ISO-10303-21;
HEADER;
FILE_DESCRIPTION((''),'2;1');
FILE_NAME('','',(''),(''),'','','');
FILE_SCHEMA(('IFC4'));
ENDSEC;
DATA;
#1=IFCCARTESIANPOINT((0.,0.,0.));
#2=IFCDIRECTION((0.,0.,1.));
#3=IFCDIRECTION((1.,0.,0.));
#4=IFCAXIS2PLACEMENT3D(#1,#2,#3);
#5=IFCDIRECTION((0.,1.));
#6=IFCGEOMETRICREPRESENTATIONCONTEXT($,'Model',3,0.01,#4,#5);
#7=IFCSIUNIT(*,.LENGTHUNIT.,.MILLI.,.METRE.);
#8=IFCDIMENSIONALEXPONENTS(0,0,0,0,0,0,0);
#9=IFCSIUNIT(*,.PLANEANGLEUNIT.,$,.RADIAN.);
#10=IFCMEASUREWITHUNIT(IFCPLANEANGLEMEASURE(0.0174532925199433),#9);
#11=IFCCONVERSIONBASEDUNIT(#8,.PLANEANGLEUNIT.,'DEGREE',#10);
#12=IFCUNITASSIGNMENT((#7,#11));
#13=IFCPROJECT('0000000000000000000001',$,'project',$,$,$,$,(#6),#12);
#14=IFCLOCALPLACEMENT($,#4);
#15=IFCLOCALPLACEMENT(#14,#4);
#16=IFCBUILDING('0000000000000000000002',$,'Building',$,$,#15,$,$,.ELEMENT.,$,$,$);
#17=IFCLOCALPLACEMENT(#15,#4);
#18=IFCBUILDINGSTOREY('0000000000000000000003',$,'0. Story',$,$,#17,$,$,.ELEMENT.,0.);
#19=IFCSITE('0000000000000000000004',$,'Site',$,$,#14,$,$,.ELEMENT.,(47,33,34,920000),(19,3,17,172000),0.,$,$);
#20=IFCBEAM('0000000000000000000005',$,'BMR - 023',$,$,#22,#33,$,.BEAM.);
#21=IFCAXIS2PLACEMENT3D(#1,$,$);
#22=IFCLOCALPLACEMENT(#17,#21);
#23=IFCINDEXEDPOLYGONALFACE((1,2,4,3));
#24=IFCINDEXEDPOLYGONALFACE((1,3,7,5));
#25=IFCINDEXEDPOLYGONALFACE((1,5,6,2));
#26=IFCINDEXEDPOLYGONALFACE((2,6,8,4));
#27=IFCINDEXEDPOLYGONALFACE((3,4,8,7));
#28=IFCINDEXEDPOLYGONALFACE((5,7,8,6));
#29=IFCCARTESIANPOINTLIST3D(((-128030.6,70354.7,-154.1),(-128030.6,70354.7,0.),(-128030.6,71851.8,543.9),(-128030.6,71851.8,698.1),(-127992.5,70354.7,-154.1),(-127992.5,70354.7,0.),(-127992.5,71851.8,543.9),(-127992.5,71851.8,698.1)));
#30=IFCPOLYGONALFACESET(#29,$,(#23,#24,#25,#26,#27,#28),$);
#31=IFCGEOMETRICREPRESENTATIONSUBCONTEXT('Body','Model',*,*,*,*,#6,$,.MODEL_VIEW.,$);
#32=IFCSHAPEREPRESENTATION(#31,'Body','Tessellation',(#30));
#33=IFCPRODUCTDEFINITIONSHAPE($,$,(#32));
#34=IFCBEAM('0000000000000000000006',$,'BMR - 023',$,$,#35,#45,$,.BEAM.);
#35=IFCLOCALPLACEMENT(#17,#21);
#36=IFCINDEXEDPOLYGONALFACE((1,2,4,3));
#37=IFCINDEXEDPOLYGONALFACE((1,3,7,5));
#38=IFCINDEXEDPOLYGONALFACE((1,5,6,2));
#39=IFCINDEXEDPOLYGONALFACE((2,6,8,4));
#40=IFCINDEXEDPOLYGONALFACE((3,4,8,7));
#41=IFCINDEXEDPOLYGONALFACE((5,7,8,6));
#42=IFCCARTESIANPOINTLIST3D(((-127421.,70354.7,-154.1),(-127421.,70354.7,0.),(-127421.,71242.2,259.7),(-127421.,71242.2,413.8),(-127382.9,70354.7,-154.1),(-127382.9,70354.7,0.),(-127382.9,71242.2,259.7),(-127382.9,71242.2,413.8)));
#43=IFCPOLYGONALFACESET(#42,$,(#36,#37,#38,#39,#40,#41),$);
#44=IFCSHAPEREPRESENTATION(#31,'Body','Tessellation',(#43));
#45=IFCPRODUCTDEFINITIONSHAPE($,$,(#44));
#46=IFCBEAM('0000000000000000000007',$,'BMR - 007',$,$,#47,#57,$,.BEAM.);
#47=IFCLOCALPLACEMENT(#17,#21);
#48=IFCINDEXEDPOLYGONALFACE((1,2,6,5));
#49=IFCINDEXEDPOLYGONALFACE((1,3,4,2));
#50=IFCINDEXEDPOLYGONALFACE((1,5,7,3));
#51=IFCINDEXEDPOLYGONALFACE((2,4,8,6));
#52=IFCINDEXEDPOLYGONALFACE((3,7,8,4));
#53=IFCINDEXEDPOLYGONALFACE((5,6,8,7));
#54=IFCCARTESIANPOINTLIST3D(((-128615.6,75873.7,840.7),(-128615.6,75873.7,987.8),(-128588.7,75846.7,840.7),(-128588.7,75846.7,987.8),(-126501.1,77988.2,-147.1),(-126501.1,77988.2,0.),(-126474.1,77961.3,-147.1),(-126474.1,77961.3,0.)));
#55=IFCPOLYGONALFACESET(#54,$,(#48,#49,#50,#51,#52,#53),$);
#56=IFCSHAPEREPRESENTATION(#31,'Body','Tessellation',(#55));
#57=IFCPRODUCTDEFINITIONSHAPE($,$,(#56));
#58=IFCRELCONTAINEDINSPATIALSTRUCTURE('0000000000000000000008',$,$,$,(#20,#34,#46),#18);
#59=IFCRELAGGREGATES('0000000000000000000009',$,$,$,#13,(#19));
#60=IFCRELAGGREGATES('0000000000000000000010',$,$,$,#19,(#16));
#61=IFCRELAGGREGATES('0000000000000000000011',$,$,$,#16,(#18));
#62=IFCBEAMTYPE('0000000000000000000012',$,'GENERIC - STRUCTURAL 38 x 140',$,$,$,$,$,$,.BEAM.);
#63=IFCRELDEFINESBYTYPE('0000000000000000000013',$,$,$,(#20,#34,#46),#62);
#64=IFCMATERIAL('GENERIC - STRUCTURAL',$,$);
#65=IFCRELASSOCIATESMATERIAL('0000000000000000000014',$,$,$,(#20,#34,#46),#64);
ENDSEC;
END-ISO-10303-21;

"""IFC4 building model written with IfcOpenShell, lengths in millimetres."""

from ifc_helpers import new_model, entity, si_unit, converted_unit, direction, frame, frame_2d, origin_with_axes, place, context, subcontext, project, spatial, rectangle, extrude, clip, halfspace, material, type_object, element, save


model = new_model("IFC4")

# Units and contexts
model_context = context("Model", 3, precision=0.01, world=origin_with_axes(), true_north=direction((0.0, 1.0)))
body_context = subcontext(model_context, "Body", "Model", "MODEL_VIEW")
ifc_project = project(units=[si_unit("LENGTHUNIT", "METRE", prefix="MILLI"), converted_unit("PLANEANGLEUNIT", "DEGREE", entity("IfcPlaneAngleMeasure", 0.0174532925199433), si_unit("PLANEANGLEUNIT", "RADIAN"), dimensions=[0, 0, 0, 0, 0, 0, 0])], contexts=[model_context])

# Site, building, storey
site_placement = place(None, origin_with_axes())
site = spatial("IfcSite", under=ifc_project, at=site_placement, Name="Site", CompositionType="ELEMENT", RefLatitude=(47, 33, 34, 920000), RefLongitude=(19, 3, 17, 172000), RefElevation=0.0)
building_placement = place(site_placement, origin_with_axes())
building = spatial("IfcBuilding", under=site, at=building_placement, Name="Building", CompositionType="ELEMENT")
storey_placement = place(building_placement, origin_with_axes())
storey = spatial("IfcBuildingStorey", under=building, at=storey_placement, Name="0. Story", CompositionType="ELEMENT", Elevation=0.0)

# Beams
ifc_material = material(Name="GENERIC - STRUCTURAL")
beam_type = type_object("IfcBeamType", Name="GENERIC - STRUCTURAL 38 x 140", PredefinedType="BEAM")
beam_1_placement = place(storey_placement, frame((-128011.6, 70354.7, 0.0), z_axis=(0.0, 0.0, 1.0), x_axis=(1.0, 0.0, 0.0)))
element("IfcBeam", 1, at=beam_1_placement, inside=storey, type_object=beam_type, material=ifc_material, Name="BMR - 023", PredefinedType="BEAM", context=body_context, shape_type="Clipping", body=[
    clip(clip(extrude(rectangle(XDim=139.7, YDim=38.1, at=frame_2d((-69.8, 0.0), x_axis=(1.0, 0.0))), frame((0.0, -83.5, -38.9), z_axis=(0.0, 0.906308, 0.422618), x_axis=(0.0, -0.422618, 0.906308)), (0.0, 0.0, 1.0), 1836.1), halfspace(frame((0.0, 0.0, 0.0), z_axis=(0.0, 1.0, 0.0), x_axis=(0.0, 0.0, 1.0)), True)), halfspace(frame((0.0, 1497.1, 0.0), z_axis=(0.0, -1.0, 0.0), x_axis=(0.0, 0.0, -1.0)), True)),
])
beam_2_placement = place(storey_placement, frame((-127402.0, 70354.7, 0.0), z_axis=(0.0, 0.0, 1.0), x_axis=(1.0, 0.0, 0.0)))
element("IfcBeam", 2, at=beam_2_placement, inside=storey, type_object=beam_type, material=ifc_material, Name="BMR - 023", PredefinedType="BEAM", context=body_context, shape_type="Clipping", body=[
    clip(clip(extrude(rectangle(XDim=139.7, YDim=38.1, at=frame_2d((-69.8, 0.0), x_axis=(1.0, 0.0))), frame((0.0, -83.5, -38.9), z_axis=(0.0, 0.906308, 0.422618), x_axis=(0.0, -0.422618, 0.906308)), (0.0, 0.0, 1.0), 1163.5), halfspace(frame((0.0, 0.0, 0.0), z_axis=(0.0, 1.0, 0.0), x_axis=(0.0, 0.0, 1.0)), True)), halfspace(frame((0.0, 887.5, 0.0), z_axis=(0.0, -1.0, 0.0), x_axis=(0.0, 0.0, -1.0)), True)),
])
beam_3_placement = place(storey_placement, frame((-126487.6, 77974.7, 0.0), z_axis=(0.0, 0.0, 1.0), x_axis=(-0.707107, 0.707107, 0.0)))
element("IfcBeam", 3, at=beam_3_placement, inside=storey, type_object=beam_type, material=ifc_material, Name="BMR - 007", PredefinedType="BEAM", context=body_context, shape_type="Clipping", body=[
    clip(clip(extrude(rectangle(XDim=139.7, YDim=38.1, at=frame_2d((-69.8, 0.0), x_axis=(1.0, 0.0))), frame((0.0, -62.0, -20.5), z_axis=(0.0, 0.94954, 0.313647), x_axis=(0.0, -0.313647, 0.94954)), (0.0, 0.0, 1.0), 3279.9), halfspace(frame((0.0, 0.0, 0.0), z_axis=(0.0, 1.0, 0.0), x_axis=(0.0, 0.0, 1.0)), True)), halfspace(frame((0.0, 2990.4, 0.0), z_axis=(0.0, -1.0, 0.0), x_axis=(0.0, 0.0, -1.0)), True)),
])

save(model, "model.ifc")
